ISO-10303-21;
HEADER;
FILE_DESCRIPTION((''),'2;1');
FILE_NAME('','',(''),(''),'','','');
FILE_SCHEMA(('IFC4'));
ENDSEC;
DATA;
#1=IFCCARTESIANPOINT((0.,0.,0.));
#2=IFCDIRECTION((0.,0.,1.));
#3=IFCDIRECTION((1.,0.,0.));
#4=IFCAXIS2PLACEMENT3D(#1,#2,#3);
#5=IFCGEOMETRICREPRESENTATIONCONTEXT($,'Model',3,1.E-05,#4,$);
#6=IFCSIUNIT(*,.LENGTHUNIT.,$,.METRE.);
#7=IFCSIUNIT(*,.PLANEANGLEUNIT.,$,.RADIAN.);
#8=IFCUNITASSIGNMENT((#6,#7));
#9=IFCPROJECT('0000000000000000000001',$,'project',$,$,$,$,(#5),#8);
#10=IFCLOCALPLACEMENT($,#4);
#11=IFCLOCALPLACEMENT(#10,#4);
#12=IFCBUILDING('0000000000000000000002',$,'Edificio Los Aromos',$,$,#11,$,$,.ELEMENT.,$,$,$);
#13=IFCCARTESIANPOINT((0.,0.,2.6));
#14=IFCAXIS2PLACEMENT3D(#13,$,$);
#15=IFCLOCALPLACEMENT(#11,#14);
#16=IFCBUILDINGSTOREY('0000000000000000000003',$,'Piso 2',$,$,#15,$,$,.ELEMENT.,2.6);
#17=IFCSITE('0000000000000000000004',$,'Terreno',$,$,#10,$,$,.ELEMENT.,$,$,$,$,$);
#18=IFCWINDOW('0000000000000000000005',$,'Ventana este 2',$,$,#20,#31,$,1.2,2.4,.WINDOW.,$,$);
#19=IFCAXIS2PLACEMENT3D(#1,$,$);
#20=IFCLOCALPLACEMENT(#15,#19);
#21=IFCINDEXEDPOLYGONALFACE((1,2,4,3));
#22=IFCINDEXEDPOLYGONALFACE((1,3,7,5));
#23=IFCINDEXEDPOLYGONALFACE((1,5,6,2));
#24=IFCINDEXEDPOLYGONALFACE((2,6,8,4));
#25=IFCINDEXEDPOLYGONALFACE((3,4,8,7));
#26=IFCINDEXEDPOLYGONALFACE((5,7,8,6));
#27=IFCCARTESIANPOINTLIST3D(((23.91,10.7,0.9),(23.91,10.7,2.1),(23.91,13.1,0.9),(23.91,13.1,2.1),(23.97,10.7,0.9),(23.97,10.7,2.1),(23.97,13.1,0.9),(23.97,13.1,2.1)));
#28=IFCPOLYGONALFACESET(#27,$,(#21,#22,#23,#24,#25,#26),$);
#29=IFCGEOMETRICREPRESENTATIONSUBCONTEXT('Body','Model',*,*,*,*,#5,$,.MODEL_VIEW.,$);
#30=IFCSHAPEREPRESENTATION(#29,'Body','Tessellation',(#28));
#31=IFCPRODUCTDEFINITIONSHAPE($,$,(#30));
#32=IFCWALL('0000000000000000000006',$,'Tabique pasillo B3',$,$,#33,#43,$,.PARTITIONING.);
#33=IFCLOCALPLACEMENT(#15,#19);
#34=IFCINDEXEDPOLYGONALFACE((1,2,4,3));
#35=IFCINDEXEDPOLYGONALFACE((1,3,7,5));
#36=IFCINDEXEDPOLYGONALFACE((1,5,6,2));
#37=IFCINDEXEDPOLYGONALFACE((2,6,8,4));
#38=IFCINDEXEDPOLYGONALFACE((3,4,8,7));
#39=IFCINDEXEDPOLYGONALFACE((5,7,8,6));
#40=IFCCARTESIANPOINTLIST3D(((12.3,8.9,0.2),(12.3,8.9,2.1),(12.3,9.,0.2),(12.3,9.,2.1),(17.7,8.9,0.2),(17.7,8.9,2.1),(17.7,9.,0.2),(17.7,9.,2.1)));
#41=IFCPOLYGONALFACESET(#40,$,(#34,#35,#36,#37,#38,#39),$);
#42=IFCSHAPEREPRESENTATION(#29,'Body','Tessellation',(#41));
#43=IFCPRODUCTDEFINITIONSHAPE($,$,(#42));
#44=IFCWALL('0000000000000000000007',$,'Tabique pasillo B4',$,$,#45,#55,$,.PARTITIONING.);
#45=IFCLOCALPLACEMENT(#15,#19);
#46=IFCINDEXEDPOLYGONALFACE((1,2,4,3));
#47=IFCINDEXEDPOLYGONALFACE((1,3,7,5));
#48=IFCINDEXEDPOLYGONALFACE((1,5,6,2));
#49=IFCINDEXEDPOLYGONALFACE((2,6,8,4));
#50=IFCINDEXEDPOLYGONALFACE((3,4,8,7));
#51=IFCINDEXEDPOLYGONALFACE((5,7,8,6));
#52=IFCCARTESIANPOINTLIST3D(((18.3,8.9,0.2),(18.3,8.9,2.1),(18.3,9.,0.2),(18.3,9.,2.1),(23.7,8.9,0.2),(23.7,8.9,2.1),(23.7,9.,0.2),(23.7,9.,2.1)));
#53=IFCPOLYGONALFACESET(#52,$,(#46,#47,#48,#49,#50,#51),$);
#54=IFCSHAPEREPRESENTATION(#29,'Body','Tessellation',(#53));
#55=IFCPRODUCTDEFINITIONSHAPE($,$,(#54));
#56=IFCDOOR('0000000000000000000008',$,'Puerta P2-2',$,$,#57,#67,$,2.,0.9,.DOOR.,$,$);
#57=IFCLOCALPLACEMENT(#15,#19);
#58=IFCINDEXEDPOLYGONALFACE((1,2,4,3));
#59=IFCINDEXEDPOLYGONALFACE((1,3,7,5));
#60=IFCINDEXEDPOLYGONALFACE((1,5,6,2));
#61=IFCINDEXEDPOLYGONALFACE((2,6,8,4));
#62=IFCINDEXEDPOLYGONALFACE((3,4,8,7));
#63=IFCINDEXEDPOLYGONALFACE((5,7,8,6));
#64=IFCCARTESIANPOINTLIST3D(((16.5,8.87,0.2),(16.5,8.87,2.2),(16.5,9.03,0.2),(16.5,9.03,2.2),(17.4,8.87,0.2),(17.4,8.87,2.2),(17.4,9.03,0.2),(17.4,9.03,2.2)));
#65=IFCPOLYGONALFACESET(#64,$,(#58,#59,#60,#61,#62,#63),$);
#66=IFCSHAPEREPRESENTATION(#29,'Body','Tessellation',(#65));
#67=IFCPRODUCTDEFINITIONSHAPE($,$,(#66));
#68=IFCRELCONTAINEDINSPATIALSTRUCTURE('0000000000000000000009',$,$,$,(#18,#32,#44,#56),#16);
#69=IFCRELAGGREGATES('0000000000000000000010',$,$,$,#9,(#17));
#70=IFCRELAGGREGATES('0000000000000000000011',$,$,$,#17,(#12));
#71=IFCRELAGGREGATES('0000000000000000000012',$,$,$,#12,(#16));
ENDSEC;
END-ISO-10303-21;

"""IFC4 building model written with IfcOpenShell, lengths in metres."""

from ifc_helpers import new_model, si_unit, frame, frame_2d, origin_with_axes, place, context, subcontext, project, spatial, rectangle, extrude, element, save


model = new_model("IFC4")

# Units and contexts
model_context = context("Model", 3, precision=1e-05, world=origin_with_axes())
body_context = subcontext(model_context, "Body", "Model", "MODEL_VIEW")
ifc_project = project(units=[si_unit("LENGTHUNIT", "METRE"), si_unit("PLANEANGLEUNIT", "RADIAN")], contexts=[model_context])

# Site, building, storey
site_placement = place(None, origin_with_axes())
site = spatial("IfcSite", under=ifc_project, at=site_placement, Name="Terreno", CompositionType="ELEMENT")
building_placement = place(site_placement, origin_with_axes())
building = spatial("IfcBuilding", under=site, at=building_placement, Name="Edificio Los Aromos", CompositionType="ELEMENT")
storey_placement = place(building_placement, frame((0.0, 0.0, 2.6)))
storey = spatial("IfcBuildingStorey", under=building, at=storey_placement, Name="Piso 2", CompositionType="ELEMENT", Elevation=2.6)

# Window
window_1_placement = place(storey_placement, frame((23.91, 10.7, 0.9)))
element("IfcWindow", 1, at=window_1_placement, inside=storey, Name="Ventana este 2", OverallHeight=1.2, OverallWidth=2.4, PredefinedType="WINDOW", context=body_context, shape_type="SweptSolid", body=[
    extrude(rectangle(XDim=0.06, YDim=2.4, at=frame_2d((0.03, 1.2))), origin_with_axes(), (0.0, 0.0, 1.0), 1.2),
])

# Walls
for number, where, name in (
    (2, (12.3, 8.9, 0.2), "Tabique pasillo B3"),
    (3, (18.3, 8.9, 0.2), "Tabique pasillo B4"),
):
    element("IfcWall", number, at=place(storey_placement, frame(where)), inside=storey, Name=name, PredefinedType="PARTITIONING", context=body_context, shape_type="SweptSolid", body=[
        extrude(rectangle(XDim=5.4, YDim=0.1, at=frame_2d((2.7, 0.05))), origin_with_axes(), (0.0, 0.0, 1.0), 1.9),
    ])

# Door
door_placement = place(storey_placement, frame((16.5, 8.87, 0.2)))
element("IfcDoor", 4, at=door_placement, inside=storey, Name="Puerta P2-2", OverallHeight=2.0, OverallWidth=0.9, PredefinedType="DOOR", context=body_context, shape_type="SweptSolid", body=[
    extrude(rectangle(XDim=0.9, YDim=0.16, at=frame_2d((0.45, 0.08))), origin_with_axes(), (0.0, 0.0, 1.0), 2.0),
])

save(model, "model.ifc")
